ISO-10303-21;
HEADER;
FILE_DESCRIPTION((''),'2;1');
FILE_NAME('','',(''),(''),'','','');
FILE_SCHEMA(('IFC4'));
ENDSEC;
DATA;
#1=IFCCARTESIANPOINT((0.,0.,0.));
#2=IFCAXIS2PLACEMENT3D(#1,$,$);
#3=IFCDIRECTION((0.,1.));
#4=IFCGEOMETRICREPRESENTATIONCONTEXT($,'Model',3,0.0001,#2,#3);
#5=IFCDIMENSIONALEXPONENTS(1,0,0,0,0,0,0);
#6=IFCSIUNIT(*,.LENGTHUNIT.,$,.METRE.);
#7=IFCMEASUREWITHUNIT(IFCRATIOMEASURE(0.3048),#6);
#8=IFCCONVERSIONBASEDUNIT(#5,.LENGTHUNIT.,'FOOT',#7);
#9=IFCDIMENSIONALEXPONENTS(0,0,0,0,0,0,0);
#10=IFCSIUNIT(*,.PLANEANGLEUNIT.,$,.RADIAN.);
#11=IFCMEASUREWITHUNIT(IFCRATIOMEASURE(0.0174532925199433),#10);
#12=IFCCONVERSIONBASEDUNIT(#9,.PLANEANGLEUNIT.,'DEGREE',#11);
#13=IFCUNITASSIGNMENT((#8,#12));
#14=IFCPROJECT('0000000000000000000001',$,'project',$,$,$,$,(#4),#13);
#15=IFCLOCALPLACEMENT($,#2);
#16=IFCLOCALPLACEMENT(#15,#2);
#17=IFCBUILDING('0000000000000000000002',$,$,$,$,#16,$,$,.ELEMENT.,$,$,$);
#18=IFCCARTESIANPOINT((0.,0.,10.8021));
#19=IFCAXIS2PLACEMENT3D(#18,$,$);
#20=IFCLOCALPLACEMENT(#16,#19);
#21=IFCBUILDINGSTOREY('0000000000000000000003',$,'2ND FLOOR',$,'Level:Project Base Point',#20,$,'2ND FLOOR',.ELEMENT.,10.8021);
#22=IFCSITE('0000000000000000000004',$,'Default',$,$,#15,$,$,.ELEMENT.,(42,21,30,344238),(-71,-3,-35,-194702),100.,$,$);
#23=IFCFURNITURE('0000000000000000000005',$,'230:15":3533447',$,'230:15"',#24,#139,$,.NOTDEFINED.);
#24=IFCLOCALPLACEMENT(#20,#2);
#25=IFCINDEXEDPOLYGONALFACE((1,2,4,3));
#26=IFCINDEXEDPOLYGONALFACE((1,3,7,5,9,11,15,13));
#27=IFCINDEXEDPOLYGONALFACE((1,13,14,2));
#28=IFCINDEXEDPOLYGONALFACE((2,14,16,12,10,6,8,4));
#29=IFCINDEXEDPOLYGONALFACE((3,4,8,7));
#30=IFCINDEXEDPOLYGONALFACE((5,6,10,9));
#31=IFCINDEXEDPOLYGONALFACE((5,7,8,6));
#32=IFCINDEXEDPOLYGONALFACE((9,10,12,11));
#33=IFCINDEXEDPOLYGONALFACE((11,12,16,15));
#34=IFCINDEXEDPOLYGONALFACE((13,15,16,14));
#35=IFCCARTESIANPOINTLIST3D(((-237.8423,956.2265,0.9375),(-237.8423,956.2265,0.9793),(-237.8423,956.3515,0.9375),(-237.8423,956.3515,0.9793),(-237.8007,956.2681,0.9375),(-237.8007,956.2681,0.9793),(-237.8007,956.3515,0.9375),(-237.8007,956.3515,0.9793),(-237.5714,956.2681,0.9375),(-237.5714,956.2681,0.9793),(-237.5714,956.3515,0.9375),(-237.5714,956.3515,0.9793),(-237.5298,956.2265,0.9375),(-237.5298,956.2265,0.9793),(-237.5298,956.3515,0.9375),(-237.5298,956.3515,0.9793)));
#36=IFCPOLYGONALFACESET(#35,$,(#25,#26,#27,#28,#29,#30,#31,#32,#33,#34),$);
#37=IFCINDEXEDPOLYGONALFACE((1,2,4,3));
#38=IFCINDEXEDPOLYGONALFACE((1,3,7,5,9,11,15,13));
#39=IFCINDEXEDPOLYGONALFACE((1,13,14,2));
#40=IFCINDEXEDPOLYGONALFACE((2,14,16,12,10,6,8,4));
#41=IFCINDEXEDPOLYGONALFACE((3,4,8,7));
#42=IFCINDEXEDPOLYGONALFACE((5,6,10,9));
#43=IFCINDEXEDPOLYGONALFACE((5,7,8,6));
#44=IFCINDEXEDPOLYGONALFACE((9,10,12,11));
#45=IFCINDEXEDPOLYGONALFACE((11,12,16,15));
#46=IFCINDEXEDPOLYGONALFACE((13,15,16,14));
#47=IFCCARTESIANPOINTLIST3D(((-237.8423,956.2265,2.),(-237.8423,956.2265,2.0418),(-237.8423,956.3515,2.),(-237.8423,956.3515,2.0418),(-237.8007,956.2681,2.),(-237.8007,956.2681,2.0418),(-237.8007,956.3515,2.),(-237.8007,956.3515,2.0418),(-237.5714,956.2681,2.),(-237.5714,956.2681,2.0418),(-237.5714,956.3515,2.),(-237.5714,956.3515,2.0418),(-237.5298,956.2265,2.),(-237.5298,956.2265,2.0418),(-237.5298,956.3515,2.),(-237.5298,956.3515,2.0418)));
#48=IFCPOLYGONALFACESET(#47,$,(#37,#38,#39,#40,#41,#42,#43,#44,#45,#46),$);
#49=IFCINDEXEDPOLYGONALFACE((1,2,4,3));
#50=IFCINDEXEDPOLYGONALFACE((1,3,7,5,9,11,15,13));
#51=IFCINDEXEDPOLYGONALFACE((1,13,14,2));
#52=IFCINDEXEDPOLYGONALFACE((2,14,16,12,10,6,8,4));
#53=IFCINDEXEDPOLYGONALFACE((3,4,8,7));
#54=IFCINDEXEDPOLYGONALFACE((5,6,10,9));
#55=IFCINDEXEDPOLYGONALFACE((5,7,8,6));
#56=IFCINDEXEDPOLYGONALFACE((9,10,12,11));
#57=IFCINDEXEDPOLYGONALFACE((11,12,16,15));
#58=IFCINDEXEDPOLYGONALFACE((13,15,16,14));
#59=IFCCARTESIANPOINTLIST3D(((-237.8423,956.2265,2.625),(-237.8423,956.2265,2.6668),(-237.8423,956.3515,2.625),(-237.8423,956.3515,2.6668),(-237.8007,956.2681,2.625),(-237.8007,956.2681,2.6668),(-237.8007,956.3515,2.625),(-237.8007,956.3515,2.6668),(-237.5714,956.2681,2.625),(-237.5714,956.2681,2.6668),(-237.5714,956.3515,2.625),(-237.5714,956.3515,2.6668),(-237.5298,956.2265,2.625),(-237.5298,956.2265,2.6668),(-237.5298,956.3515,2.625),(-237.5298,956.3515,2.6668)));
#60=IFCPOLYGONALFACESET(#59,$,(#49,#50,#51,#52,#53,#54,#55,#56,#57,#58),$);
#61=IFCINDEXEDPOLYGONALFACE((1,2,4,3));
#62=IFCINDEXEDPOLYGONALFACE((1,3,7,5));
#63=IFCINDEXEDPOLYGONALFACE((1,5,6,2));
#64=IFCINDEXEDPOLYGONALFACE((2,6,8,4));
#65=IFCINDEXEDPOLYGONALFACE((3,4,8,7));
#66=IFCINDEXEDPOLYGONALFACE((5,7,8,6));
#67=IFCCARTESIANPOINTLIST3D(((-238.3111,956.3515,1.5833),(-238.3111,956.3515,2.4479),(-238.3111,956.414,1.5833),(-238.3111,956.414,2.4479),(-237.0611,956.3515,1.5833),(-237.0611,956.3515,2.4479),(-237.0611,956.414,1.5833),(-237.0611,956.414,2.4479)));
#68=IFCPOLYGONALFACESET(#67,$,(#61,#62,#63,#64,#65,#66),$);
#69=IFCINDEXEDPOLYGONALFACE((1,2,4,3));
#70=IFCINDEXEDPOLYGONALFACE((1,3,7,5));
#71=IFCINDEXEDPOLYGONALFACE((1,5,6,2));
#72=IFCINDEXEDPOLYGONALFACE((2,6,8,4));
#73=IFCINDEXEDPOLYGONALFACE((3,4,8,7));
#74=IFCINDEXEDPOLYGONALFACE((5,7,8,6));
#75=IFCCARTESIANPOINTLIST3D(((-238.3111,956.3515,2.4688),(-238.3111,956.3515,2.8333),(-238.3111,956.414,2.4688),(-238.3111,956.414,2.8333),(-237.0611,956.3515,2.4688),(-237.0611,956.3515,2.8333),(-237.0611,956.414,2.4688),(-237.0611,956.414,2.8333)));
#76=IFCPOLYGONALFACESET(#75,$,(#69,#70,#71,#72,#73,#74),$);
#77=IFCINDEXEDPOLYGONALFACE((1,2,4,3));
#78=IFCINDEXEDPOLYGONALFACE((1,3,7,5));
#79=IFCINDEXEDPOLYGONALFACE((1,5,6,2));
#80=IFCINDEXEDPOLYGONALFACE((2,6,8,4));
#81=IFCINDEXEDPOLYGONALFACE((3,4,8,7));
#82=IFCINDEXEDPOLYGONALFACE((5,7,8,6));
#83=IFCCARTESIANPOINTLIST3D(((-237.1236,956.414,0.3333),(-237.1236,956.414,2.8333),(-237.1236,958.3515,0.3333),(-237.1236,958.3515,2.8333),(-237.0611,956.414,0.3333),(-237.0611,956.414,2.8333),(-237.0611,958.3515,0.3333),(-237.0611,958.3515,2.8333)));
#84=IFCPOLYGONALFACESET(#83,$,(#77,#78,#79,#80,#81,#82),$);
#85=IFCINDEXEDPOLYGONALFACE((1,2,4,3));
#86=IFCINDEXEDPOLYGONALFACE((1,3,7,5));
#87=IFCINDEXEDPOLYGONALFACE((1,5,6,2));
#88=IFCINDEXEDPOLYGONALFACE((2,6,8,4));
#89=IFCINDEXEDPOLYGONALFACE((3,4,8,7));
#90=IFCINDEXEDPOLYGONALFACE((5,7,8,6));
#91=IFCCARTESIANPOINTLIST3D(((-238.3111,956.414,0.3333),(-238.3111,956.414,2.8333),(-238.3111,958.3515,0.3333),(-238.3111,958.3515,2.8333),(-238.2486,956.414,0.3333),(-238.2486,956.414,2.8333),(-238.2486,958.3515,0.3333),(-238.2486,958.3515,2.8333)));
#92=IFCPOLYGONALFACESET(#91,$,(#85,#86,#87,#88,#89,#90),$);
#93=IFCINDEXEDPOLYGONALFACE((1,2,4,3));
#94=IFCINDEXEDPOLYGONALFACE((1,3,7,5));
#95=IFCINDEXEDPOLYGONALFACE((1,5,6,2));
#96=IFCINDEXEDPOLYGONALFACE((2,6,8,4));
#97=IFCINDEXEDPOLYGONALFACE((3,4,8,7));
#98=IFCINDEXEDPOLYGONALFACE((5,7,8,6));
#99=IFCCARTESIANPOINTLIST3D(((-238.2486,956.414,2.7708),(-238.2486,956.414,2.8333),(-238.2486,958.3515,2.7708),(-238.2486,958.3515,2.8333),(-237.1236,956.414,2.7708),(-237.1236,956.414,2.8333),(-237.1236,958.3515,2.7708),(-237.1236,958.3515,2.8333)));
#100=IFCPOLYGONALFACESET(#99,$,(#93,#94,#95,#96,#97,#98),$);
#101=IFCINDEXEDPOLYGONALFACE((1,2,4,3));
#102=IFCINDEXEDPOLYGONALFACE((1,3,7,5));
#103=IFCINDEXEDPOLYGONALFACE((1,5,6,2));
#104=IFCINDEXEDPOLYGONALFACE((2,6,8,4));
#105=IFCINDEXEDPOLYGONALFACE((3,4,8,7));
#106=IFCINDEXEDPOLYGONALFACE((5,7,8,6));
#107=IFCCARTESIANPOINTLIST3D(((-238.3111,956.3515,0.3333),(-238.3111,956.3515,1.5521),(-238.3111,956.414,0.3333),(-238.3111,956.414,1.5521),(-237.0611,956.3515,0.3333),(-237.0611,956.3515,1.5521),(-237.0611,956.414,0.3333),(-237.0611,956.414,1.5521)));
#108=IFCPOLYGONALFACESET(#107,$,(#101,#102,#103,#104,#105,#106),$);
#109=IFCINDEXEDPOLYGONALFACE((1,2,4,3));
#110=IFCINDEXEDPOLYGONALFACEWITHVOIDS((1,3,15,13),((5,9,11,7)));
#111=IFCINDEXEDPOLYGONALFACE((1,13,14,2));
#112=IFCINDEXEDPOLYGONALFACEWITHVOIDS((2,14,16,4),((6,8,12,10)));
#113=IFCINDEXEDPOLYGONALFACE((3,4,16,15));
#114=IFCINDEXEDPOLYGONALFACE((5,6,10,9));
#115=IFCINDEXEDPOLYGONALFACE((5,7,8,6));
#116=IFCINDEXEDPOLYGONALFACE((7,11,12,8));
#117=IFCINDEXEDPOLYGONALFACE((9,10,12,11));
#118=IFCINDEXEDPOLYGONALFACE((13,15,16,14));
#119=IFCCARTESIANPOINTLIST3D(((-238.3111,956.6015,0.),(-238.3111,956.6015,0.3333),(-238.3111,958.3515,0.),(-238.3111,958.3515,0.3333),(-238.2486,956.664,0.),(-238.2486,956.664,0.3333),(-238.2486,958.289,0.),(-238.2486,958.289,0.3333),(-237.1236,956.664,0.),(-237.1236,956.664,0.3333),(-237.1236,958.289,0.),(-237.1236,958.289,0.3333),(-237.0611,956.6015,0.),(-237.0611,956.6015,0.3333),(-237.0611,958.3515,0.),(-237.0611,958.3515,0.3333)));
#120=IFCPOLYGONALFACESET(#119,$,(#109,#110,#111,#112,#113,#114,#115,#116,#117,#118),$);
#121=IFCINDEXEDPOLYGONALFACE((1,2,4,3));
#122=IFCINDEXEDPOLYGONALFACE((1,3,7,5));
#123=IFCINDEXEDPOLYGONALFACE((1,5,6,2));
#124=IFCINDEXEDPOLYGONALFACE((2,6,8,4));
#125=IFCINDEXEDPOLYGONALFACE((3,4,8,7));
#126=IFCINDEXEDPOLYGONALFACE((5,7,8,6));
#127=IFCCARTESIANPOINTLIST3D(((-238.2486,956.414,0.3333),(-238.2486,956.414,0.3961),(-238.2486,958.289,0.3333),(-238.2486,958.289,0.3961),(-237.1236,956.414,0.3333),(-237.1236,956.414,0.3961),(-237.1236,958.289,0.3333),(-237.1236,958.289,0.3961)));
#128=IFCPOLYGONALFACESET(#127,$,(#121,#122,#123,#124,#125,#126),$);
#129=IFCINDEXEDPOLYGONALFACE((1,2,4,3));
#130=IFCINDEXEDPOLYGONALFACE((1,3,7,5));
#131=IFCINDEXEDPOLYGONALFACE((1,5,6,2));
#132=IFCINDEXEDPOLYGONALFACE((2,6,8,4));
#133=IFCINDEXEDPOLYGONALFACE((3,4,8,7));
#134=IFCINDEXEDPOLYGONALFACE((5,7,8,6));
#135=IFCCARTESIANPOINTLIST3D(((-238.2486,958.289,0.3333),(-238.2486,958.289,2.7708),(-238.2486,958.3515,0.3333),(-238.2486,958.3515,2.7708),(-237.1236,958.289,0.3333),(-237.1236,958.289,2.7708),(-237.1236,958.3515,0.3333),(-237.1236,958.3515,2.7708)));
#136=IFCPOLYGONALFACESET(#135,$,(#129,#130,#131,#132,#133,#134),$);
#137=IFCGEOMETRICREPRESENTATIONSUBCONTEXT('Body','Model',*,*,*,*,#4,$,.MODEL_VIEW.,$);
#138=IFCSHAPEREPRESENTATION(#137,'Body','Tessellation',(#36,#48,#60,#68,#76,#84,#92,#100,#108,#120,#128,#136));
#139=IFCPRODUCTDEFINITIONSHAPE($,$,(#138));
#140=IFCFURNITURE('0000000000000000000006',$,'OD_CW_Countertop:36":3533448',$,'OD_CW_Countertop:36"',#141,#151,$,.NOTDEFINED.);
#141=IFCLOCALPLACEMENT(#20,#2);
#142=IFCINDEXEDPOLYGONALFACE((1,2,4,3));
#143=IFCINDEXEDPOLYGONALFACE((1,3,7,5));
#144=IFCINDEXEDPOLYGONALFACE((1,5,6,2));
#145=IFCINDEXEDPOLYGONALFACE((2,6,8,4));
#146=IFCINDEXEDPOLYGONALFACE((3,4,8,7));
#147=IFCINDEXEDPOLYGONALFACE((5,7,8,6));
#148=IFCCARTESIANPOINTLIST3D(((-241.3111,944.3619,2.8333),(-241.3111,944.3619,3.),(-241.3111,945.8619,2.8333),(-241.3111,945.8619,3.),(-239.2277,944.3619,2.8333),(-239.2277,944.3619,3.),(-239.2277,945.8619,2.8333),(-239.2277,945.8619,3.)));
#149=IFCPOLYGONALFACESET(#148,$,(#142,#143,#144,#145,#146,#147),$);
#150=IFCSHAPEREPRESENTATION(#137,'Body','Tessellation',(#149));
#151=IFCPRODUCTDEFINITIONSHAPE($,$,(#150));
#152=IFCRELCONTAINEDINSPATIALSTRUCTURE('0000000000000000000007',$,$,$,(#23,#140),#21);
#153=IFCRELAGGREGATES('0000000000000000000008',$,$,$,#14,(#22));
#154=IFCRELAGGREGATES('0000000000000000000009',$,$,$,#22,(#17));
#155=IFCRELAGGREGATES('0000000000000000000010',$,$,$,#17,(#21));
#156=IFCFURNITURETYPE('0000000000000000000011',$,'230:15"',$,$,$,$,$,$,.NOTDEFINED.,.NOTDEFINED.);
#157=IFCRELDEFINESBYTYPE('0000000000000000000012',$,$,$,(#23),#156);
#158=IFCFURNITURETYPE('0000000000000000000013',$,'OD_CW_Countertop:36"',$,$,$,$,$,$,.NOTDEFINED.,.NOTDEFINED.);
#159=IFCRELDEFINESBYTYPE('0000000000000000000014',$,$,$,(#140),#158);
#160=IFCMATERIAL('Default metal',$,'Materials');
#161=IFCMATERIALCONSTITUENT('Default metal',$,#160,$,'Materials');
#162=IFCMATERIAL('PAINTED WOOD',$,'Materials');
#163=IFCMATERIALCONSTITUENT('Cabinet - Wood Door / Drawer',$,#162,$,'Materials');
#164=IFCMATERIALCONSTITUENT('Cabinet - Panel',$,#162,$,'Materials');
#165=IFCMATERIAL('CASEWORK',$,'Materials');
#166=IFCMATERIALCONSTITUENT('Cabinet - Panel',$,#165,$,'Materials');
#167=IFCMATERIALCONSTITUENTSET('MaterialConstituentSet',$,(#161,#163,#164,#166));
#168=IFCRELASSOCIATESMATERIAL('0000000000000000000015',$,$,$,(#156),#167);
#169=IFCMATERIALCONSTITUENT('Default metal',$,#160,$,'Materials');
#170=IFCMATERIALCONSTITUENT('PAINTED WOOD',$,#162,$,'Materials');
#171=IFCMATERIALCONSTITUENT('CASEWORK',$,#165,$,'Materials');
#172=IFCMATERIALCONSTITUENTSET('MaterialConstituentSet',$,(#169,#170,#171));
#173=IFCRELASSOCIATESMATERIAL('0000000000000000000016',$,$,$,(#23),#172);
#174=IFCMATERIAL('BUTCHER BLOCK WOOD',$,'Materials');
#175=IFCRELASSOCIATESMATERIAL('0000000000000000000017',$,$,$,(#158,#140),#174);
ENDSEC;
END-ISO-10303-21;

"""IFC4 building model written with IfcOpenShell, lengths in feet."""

from ifc_helpers import new_model, entity, si_unit, converted_unit, direction, frame, frame_2d, origin, origin_2d_with_axis, place, context, subcontext, project, spatial, polyline, rectangle, outline, extrude, source, transform, mapped, material, constituent, constituent_set, type_object, type_shapes, element, save


model = new_model("IFC4")

# Units and contexts
model_context = context("Model", 3, precision=0.0001, world=origin(), true_north=direction((0.0, 1.0)))
body_context = subcontext(model_context, "Body", "Model", "MODEL_VIEW")
ifc_project = project(units=[converted_unit("LENGTHUNIT", "FOOT", entity("IfcRatioMeasure", 0.3048), si_unit("LENGTHUNIT", "METRE"), dimensions=[1, 0, 0, 0, 0, 0, 0]), converted_unit("PLANEANGLEUNIT", "DEGREE", entity("IfcRatioMeasure", 0.0174532925199433), si_unit("PLANEANGLEUNIT", "RADIAN"), dimensions=[0, 0, 0, 0, 0, 0, 0])], contexts=[model_context])

# Site, building, storey
site_placement = place(None, origin())
site = spatial("IfcSite", under=ifc_project, at=site_placement, Name="Default", CompositionType="ELEMENT", RefLatitude=(42, 21, 30, 344238), RefLongitude=(-71, -3, -35, -194702), RefElevation=100.0)
building_placement = place(site_placement, origin())
building = spatial("IfcBuilding", under=site, at=building_placement, CompositionType="ELEMENT")
storey_placement = place(building_placement, frame((0.0, 0.0, 10.8021)))
storey = spatial("IfcBuildingStorey", under=building, at=storey_placement, Name="2ND FLOOR", ObjectType="Level:Project Base Point", LongName="2ND FLOOR", CompositionType="ELEMENT", Elevation=10.8021)

# Shared definitions
ifc_material_1 = material(Name="Default metal", Category="Materials")
ifc_material_2 = material(Name="PAINTED WOOD", Category="Materials")
ifc_material_3 = material(Name="CASEWORK", Category="Materials")

# Furniture
ifc_material_4 = material(Name="BUTCHER BLOCK WOOD", Category="Materials")
ifc_constituent_1 = constituent(ifc_material_1, Name="Default metal", Category="Materials")
ifc_constituent_2 = constituent(ifc_material_2, Name="PAINTED WOOD", Category="Materials")
ifc_constituent_3 = constituent(ifc_material_3, Name="CASEWORK", Category="Materials")
ifc_constituent_set_1 = constituent_set(constituents=[ifc_constituent_1, ifc_constituent_2, ifc_constituent_3], Name="MaterialConstituentSet")
ifc_constituent_4 = constituent(ifc_material_1, Name="Default metal", Category="Materials")
ifc_constituent_5 = constituent(ifc_material_2, Name="Cabinet - Wood Door / Drawer", Category="Materials")
ifc_constituent_6 = constituent(ifc_material_2, Name="Cabinet - Panel", Category="Materials")
ifc_constituent_7 = constituent(ifc_material_3, Name="Cabinet - Panel", Category="Materials")
ifc_constituent_set_2 = constituent_set(constituents=[ifc_constituent_4, ifc_constituent_5, ifc_constituent_6, ifc_constituent_7], Name="MaterialConstituentSet")
furniture_type_1 = type_object("IfcFurnitureType", Name="230:15\"", AssemblyPlace="NOTDEFINED", PredefinedType="NOTDEFINED", material=ifc_constituent_set_2)
shared_shape_1 = source(origin(), body_context, "Body", "SweptSolid", [
    extrude(outline(polyline([(-0.1562, -0.0521), (-0.1146, -0.0521), (-0.1146, 0.0313), (0.1146, 0.0313), (0.1146, -0.0521), (0.1562, -0.0521), (0.1562, 0.0729), (-0.1562, 0.0729), (-0.1562, -0.0521)])), frame((0.0615, 2.0521, 0.9375)), (0.0, 0.0, 1.0), 0.0418),
    extrude(outline(polyline([(-0.1562, -0.0521), (-0.1146, -0.0521), (-0.1146, 0.0313), (0.1146, 0.0313), (0.1146, -0.0521), (0.1562, -0.0521), (0.1562, 0.0729), (-0.1562, 0.0729), (-0.1562, -0.0521)])), frame((0.0615, 2.0521, 2.0)), (0.0, 0.0, 1.0), 0.0418),
    extrude(outline(polyline([(-0.1562, -0.0521), (-0.1146, -0.0521), (-0.1146, 0.0313), (0.1146, 0.0313), (0.1146, -0.0521), (0.1562, -0.0521), (0.1562, 0.0729), (-0.1562, 0.0729), (-0.1562, -0.0521)])), frame((0.0615, 2.0521, 2.625)), (0.0, 0.0, 1.0), 0.0418),
    extrude(rectangle(XDim=1.25, YDim=0.0625, at=frame_2d((0.0, 0.0), x_axis=(1.0, 0.0))), frame((0.0615, 1.9688, 1.5833), z_axis=(0.0, 0.0, 1.0), x_axis=(-1.0, 0.0, 0.0)), (0.0, 0.0, 1.0), 0.8646),
    extrude(rectangle(XDim=1.25, YDim=0.0625, at=frame_2d((0.0, 0.0), x_axis=(1.0, 0.0))), frame((0.0615, 1.9688, 2.4688), z_axis=(0.0, 0.0, 1.0), x_axis=(-1.0, 0.0, 0.0)), (0.0, 0.0, 1.0), 0.3646),
    extrude(rectangle(XDim=1.9375, YDim=0.0625, at=frame_2d((0.0, 0.0), x_axis=(1.0, 0.0))), frame((-0.5323, 0.9687, 0.3333), z_axis=(0.0, 0.0, 1.0), x_axis=(0.0, -1.0, 0.0)), (0.0, 0.0, 1.0), 2.5),
    extrude(rectangle(XDim=1.9375, YDim=0.0625, at=frame_2d((0.0, 0.0), x_axis=(1.0, 0.0))), frame((0.6552, 0.9687, 0.3333), z_axis=(0.0, 0.0, 1.0), x_axis=(0.0, -1.0, 0.0)), (0.0, 0.0, 1.0), 2.5),
    extrude(rectangle(XDim=1.9375, YDim=1.125, at=origin_2d_with_axis()), frame((0.0615, 0.9687, 2.7708), z_axis=(0.0, 0.0, 1.0), x_axis=(0.0, 1.0, 0.0)), (0.0, 0.0, 1.0), 0.0625),
    extrude(rectangle(XDim=1.25, YDim=0.0625, at=frame_2d((0.0, 0.0), x_axis=(1.0, 0.0))), frame((0.0615, 1.9688, 0.3333), z_axis=(0.0, 0.0, 1.0), x_axis=(-1.0, 0.0, 0.0)), (0.0, 0.0, 1.0), 1.2187),
    extrude(outline(polyline([(-0.875, -0.625), (0.875, -0.625), (0.875, 0.625), (-0.875, 0.625), (-0.875, -0.625)]), holes=[polyline([(-0.8125, -0.5625), (-0.8125, 0.5625), (0.8125, 0.5625), (0.8125, -0.5625), (-0.8125, -0.5625)])]), frame((0.0615, 0.875, 0.0), z_axis=(0.0, 0.0, 1.0), x_axis=(0.0, -1.0, 0.0)), (0.0, 0.0, 1.0), 0.3333),
    extrude(rectangle(XDim=1.875, YDim=1.125, at=origin_2d_with_axis()), frame((0.0615, 1.0, 0.3333), z_axis=(0.0, 0.0, 1.0), x_axis=(0.0, 1.0, 0.0)), (0.0, 0.0, 1.0), 0.0627),
    extrude(rectangle(XDim=1.125, YDim=0.0625, at=origin_2d_with_axis()), frame((0.0615, 0.0312, 0.3333), z_axis=(0.0, 0.0, 1.0), x_axis=(-1.0, 0.0, 0.0)), (0.0, 0.0, 1.0), 2.4375),
])
type_shapes(furniture_type_1, [shared_shape_1])
furniture_1_placement = place(storey_placement, frame((-237.6246, 958.3515, 0.0), z_axis=(0.0, 0.0, 1.0), x_axis=(-1.0, 0.0, 0.0)))
element("IfcFurniture", 1, at=furniture_1_placement, inside=storey, type_object=furniture_type_1, material=ifc_constituent_set_1, Name="230:15\":3533447", ObjectType="230:15\"", PredefinedType="NOTDEFINED", context=body_context, shape_type="MappedRepresentation", body=[
    mapped(shared_shape_1, transform((0.0, 0.0, 0.0), scale=1.0)),
])
furniture_type_2 = type_object("IfcFurnitureType", Name="OD_CW_Countertop:36\"", AssemblyPlace="NOTDEFINED", PredefinedType="NOTDEFINED", material=ifc_material_4)
shared_shape_2 = source(origin(), body_context, "Body", "SweptSolid", [
    extrude(rectangle(XDim=2.0833, YDim=1.5, at=origin_2d_with_axis()), frame((0.75, 1.0417, 0.0), z_axis=(0.0, 0.0, 1.0), x_axis=(0.0, -1.0, 0.0)), (0.0, 0.0, 1.0), 0.1667),
])
type_shapes(furniture_type_2, [shared_shape_2])
furniture_2_placement = place(storey_placement, frame((-239.2277, 944.3619, 2.8333), z_axis=(0.0, 0.0, 1.0), x_axis=(0.0, 1.0, 0.0)))
element("IfcFurniture", 2, at=furniture_2_placement, inside=storey, type_object=furniture_type_2, material=ifc_material_4, Name="OD_CW_Countertop:36\":3533448", ObjectType="OD_CW_Countertop:36\"", PredefinedType="NOTDEFINED", context=body_context, shape_type="MappedRepresentation", body=[
    mapped(shared_shape_2, transform((0.0, 0.0, 0.0), scale=1.0)),
])

save(model, "model.ifc")
